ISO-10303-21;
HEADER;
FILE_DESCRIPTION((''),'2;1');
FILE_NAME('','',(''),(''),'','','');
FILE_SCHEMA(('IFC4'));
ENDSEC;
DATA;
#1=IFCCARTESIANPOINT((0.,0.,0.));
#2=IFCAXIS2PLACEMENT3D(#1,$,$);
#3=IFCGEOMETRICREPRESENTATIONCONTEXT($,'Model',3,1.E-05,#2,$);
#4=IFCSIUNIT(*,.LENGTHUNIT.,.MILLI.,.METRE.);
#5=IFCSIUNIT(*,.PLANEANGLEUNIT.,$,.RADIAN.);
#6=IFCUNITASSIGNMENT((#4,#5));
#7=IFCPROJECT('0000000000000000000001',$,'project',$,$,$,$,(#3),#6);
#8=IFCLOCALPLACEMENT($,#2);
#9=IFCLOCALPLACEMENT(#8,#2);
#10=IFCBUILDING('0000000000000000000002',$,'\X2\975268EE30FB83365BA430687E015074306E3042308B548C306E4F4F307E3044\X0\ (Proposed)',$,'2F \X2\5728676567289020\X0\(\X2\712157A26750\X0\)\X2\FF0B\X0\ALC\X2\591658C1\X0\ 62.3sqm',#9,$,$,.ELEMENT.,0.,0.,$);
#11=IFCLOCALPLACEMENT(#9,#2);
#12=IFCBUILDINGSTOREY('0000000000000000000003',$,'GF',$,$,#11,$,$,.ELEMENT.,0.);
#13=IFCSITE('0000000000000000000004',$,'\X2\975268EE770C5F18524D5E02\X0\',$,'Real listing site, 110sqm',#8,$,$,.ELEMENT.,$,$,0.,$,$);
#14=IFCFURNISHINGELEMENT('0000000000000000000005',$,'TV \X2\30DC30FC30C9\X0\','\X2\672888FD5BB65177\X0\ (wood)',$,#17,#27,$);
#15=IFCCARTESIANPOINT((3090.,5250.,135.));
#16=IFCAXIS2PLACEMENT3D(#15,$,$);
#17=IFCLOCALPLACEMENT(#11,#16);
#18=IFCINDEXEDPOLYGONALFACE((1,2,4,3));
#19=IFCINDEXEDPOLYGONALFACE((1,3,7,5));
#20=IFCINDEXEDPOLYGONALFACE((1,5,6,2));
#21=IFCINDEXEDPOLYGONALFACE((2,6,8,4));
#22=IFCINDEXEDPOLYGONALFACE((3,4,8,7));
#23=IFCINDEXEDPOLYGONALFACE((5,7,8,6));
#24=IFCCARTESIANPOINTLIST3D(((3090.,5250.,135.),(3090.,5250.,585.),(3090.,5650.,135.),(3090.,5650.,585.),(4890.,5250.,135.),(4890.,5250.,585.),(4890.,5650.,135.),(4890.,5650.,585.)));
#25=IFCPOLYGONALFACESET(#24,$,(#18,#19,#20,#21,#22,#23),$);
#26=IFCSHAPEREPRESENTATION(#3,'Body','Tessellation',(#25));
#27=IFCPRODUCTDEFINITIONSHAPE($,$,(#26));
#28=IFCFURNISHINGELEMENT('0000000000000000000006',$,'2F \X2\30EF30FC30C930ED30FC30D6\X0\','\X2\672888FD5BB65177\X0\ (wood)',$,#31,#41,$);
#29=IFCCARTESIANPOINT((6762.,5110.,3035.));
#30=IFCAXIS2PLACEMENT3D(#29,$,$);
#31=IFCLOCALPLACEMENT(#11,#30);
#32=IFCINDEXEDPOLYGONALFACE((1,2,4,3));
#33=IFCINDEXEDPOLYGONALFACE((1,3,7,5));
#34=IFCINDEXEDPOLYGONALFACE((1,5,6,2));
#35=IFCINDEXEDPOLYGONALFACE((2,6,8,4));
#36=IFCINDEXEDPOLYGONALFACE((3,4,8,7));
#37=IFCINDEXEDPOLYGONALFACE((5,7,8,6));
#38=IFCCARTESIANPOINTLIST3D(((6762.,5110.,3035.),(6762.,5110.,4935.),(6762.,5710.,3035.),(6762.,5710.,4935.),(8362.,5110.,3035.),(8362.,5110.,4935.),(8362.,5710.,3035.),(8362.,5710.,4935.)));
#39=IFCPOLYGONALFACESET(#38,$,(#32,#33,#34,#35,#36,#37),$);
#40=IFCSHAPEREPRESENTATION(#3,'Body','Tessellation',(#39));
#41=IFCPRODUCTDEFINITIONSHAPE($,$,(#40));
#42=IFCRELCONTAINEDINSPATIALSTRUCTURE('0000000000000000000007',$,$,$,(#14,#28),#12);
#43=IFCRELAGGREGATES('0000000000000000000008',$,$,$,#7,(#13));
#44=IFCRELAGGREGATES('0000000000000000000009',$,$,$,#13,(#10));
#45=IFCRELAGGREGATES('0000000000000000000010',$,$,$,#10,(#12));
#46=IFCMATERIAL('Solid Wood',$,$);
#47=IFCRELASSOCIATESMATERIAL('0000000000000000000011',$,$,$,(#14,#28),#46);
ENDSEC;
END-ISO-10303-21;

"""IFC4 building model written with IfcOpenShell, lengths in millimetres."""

from ifc_helpers import new_model, si_unit, frame, frame_2d, origin, place, context, project, spatial, rectangle, extrude, material, element, save


model = new_model("IFC4")

# Units and contexts
model_context = context("Model", 3, precision=1e-05, world=origin())
ifc_project = project(units=[si_unit("LENGTHUNIT", "METRE", prefix="MILLI"), si_unit("PLANEANGLEUNIT", "RADIAN")], contexts=[model_context])

# Site, building, storey
site_placement = place(None, origin())
site = spatial("IfcSite", under=ifc_project, at=site_placement, Name="青森県弘前市", ObjectType="Real listing site, 110sqm", CompositionType="ELEMENT", RefElevation=0.0)
building_placement = place(site_placement, origin())
building = spatial("IfcBuilding", under=site, at=building_placement, Name="青森・茶室と縁側のある和の住まい (Proposed)", ObjectType="2F 在来木造(無垢材)＋ALC外壁 62.3sqm", CompositionType="ELEMENT", ElevationOfRefHeight=0.0, ElevationOfTerrain=0.0)
storey_placement = place(building_placement, origin())
storey = spatial("IfcBuildingStorey", under=building, at=storey_placement, Name="GF", CompositionType="ELEMENT", Elevation=0.0)

# Shared definitions
ifc_material_1 = material(Name="Solid Wood")

# Furnishing elements
furnishing_1_placement = place(storey_placement, frame((3090.0, 5250.0, 135.0)))
element("IfcFurnishingElement", 1, at=furnishing_1_placement, inside=storey, material=ifc_material_1, Name="TV ボード", Description="木製家具 (wood)", context=model_context, shape_type="SweptSolid", body=[
    extrude(rectangle(XDim=1800.0, YDim=400.0, at=frame_2d((900.0, 200.0))), frame((3090.0, 5250.0, 135.0)), (0.0, 0.0, 1.0), 450.0),
])
furnishing_2_placement = place(storey_placement, frame((6762.0, 5110.0, 3035.0)))
element("IfcFurnishingElement", 2, at=furnishing_2_placement, inside=storey, material=ifc_material_1, Name="2F ワードローブ", Description="木製家具 (wood)", context=model_context, shape_type="SweptSolid", body=[
    extrude(rectangle(XDim=1600.0, YDim=600.0, at=frame_2d((800.0, 300.0))), frame((6762.0, 5110.0, 3035.0)), (0.0, 0.0, 1.0), 1900.0),
])

save(model, "model.ifc")
